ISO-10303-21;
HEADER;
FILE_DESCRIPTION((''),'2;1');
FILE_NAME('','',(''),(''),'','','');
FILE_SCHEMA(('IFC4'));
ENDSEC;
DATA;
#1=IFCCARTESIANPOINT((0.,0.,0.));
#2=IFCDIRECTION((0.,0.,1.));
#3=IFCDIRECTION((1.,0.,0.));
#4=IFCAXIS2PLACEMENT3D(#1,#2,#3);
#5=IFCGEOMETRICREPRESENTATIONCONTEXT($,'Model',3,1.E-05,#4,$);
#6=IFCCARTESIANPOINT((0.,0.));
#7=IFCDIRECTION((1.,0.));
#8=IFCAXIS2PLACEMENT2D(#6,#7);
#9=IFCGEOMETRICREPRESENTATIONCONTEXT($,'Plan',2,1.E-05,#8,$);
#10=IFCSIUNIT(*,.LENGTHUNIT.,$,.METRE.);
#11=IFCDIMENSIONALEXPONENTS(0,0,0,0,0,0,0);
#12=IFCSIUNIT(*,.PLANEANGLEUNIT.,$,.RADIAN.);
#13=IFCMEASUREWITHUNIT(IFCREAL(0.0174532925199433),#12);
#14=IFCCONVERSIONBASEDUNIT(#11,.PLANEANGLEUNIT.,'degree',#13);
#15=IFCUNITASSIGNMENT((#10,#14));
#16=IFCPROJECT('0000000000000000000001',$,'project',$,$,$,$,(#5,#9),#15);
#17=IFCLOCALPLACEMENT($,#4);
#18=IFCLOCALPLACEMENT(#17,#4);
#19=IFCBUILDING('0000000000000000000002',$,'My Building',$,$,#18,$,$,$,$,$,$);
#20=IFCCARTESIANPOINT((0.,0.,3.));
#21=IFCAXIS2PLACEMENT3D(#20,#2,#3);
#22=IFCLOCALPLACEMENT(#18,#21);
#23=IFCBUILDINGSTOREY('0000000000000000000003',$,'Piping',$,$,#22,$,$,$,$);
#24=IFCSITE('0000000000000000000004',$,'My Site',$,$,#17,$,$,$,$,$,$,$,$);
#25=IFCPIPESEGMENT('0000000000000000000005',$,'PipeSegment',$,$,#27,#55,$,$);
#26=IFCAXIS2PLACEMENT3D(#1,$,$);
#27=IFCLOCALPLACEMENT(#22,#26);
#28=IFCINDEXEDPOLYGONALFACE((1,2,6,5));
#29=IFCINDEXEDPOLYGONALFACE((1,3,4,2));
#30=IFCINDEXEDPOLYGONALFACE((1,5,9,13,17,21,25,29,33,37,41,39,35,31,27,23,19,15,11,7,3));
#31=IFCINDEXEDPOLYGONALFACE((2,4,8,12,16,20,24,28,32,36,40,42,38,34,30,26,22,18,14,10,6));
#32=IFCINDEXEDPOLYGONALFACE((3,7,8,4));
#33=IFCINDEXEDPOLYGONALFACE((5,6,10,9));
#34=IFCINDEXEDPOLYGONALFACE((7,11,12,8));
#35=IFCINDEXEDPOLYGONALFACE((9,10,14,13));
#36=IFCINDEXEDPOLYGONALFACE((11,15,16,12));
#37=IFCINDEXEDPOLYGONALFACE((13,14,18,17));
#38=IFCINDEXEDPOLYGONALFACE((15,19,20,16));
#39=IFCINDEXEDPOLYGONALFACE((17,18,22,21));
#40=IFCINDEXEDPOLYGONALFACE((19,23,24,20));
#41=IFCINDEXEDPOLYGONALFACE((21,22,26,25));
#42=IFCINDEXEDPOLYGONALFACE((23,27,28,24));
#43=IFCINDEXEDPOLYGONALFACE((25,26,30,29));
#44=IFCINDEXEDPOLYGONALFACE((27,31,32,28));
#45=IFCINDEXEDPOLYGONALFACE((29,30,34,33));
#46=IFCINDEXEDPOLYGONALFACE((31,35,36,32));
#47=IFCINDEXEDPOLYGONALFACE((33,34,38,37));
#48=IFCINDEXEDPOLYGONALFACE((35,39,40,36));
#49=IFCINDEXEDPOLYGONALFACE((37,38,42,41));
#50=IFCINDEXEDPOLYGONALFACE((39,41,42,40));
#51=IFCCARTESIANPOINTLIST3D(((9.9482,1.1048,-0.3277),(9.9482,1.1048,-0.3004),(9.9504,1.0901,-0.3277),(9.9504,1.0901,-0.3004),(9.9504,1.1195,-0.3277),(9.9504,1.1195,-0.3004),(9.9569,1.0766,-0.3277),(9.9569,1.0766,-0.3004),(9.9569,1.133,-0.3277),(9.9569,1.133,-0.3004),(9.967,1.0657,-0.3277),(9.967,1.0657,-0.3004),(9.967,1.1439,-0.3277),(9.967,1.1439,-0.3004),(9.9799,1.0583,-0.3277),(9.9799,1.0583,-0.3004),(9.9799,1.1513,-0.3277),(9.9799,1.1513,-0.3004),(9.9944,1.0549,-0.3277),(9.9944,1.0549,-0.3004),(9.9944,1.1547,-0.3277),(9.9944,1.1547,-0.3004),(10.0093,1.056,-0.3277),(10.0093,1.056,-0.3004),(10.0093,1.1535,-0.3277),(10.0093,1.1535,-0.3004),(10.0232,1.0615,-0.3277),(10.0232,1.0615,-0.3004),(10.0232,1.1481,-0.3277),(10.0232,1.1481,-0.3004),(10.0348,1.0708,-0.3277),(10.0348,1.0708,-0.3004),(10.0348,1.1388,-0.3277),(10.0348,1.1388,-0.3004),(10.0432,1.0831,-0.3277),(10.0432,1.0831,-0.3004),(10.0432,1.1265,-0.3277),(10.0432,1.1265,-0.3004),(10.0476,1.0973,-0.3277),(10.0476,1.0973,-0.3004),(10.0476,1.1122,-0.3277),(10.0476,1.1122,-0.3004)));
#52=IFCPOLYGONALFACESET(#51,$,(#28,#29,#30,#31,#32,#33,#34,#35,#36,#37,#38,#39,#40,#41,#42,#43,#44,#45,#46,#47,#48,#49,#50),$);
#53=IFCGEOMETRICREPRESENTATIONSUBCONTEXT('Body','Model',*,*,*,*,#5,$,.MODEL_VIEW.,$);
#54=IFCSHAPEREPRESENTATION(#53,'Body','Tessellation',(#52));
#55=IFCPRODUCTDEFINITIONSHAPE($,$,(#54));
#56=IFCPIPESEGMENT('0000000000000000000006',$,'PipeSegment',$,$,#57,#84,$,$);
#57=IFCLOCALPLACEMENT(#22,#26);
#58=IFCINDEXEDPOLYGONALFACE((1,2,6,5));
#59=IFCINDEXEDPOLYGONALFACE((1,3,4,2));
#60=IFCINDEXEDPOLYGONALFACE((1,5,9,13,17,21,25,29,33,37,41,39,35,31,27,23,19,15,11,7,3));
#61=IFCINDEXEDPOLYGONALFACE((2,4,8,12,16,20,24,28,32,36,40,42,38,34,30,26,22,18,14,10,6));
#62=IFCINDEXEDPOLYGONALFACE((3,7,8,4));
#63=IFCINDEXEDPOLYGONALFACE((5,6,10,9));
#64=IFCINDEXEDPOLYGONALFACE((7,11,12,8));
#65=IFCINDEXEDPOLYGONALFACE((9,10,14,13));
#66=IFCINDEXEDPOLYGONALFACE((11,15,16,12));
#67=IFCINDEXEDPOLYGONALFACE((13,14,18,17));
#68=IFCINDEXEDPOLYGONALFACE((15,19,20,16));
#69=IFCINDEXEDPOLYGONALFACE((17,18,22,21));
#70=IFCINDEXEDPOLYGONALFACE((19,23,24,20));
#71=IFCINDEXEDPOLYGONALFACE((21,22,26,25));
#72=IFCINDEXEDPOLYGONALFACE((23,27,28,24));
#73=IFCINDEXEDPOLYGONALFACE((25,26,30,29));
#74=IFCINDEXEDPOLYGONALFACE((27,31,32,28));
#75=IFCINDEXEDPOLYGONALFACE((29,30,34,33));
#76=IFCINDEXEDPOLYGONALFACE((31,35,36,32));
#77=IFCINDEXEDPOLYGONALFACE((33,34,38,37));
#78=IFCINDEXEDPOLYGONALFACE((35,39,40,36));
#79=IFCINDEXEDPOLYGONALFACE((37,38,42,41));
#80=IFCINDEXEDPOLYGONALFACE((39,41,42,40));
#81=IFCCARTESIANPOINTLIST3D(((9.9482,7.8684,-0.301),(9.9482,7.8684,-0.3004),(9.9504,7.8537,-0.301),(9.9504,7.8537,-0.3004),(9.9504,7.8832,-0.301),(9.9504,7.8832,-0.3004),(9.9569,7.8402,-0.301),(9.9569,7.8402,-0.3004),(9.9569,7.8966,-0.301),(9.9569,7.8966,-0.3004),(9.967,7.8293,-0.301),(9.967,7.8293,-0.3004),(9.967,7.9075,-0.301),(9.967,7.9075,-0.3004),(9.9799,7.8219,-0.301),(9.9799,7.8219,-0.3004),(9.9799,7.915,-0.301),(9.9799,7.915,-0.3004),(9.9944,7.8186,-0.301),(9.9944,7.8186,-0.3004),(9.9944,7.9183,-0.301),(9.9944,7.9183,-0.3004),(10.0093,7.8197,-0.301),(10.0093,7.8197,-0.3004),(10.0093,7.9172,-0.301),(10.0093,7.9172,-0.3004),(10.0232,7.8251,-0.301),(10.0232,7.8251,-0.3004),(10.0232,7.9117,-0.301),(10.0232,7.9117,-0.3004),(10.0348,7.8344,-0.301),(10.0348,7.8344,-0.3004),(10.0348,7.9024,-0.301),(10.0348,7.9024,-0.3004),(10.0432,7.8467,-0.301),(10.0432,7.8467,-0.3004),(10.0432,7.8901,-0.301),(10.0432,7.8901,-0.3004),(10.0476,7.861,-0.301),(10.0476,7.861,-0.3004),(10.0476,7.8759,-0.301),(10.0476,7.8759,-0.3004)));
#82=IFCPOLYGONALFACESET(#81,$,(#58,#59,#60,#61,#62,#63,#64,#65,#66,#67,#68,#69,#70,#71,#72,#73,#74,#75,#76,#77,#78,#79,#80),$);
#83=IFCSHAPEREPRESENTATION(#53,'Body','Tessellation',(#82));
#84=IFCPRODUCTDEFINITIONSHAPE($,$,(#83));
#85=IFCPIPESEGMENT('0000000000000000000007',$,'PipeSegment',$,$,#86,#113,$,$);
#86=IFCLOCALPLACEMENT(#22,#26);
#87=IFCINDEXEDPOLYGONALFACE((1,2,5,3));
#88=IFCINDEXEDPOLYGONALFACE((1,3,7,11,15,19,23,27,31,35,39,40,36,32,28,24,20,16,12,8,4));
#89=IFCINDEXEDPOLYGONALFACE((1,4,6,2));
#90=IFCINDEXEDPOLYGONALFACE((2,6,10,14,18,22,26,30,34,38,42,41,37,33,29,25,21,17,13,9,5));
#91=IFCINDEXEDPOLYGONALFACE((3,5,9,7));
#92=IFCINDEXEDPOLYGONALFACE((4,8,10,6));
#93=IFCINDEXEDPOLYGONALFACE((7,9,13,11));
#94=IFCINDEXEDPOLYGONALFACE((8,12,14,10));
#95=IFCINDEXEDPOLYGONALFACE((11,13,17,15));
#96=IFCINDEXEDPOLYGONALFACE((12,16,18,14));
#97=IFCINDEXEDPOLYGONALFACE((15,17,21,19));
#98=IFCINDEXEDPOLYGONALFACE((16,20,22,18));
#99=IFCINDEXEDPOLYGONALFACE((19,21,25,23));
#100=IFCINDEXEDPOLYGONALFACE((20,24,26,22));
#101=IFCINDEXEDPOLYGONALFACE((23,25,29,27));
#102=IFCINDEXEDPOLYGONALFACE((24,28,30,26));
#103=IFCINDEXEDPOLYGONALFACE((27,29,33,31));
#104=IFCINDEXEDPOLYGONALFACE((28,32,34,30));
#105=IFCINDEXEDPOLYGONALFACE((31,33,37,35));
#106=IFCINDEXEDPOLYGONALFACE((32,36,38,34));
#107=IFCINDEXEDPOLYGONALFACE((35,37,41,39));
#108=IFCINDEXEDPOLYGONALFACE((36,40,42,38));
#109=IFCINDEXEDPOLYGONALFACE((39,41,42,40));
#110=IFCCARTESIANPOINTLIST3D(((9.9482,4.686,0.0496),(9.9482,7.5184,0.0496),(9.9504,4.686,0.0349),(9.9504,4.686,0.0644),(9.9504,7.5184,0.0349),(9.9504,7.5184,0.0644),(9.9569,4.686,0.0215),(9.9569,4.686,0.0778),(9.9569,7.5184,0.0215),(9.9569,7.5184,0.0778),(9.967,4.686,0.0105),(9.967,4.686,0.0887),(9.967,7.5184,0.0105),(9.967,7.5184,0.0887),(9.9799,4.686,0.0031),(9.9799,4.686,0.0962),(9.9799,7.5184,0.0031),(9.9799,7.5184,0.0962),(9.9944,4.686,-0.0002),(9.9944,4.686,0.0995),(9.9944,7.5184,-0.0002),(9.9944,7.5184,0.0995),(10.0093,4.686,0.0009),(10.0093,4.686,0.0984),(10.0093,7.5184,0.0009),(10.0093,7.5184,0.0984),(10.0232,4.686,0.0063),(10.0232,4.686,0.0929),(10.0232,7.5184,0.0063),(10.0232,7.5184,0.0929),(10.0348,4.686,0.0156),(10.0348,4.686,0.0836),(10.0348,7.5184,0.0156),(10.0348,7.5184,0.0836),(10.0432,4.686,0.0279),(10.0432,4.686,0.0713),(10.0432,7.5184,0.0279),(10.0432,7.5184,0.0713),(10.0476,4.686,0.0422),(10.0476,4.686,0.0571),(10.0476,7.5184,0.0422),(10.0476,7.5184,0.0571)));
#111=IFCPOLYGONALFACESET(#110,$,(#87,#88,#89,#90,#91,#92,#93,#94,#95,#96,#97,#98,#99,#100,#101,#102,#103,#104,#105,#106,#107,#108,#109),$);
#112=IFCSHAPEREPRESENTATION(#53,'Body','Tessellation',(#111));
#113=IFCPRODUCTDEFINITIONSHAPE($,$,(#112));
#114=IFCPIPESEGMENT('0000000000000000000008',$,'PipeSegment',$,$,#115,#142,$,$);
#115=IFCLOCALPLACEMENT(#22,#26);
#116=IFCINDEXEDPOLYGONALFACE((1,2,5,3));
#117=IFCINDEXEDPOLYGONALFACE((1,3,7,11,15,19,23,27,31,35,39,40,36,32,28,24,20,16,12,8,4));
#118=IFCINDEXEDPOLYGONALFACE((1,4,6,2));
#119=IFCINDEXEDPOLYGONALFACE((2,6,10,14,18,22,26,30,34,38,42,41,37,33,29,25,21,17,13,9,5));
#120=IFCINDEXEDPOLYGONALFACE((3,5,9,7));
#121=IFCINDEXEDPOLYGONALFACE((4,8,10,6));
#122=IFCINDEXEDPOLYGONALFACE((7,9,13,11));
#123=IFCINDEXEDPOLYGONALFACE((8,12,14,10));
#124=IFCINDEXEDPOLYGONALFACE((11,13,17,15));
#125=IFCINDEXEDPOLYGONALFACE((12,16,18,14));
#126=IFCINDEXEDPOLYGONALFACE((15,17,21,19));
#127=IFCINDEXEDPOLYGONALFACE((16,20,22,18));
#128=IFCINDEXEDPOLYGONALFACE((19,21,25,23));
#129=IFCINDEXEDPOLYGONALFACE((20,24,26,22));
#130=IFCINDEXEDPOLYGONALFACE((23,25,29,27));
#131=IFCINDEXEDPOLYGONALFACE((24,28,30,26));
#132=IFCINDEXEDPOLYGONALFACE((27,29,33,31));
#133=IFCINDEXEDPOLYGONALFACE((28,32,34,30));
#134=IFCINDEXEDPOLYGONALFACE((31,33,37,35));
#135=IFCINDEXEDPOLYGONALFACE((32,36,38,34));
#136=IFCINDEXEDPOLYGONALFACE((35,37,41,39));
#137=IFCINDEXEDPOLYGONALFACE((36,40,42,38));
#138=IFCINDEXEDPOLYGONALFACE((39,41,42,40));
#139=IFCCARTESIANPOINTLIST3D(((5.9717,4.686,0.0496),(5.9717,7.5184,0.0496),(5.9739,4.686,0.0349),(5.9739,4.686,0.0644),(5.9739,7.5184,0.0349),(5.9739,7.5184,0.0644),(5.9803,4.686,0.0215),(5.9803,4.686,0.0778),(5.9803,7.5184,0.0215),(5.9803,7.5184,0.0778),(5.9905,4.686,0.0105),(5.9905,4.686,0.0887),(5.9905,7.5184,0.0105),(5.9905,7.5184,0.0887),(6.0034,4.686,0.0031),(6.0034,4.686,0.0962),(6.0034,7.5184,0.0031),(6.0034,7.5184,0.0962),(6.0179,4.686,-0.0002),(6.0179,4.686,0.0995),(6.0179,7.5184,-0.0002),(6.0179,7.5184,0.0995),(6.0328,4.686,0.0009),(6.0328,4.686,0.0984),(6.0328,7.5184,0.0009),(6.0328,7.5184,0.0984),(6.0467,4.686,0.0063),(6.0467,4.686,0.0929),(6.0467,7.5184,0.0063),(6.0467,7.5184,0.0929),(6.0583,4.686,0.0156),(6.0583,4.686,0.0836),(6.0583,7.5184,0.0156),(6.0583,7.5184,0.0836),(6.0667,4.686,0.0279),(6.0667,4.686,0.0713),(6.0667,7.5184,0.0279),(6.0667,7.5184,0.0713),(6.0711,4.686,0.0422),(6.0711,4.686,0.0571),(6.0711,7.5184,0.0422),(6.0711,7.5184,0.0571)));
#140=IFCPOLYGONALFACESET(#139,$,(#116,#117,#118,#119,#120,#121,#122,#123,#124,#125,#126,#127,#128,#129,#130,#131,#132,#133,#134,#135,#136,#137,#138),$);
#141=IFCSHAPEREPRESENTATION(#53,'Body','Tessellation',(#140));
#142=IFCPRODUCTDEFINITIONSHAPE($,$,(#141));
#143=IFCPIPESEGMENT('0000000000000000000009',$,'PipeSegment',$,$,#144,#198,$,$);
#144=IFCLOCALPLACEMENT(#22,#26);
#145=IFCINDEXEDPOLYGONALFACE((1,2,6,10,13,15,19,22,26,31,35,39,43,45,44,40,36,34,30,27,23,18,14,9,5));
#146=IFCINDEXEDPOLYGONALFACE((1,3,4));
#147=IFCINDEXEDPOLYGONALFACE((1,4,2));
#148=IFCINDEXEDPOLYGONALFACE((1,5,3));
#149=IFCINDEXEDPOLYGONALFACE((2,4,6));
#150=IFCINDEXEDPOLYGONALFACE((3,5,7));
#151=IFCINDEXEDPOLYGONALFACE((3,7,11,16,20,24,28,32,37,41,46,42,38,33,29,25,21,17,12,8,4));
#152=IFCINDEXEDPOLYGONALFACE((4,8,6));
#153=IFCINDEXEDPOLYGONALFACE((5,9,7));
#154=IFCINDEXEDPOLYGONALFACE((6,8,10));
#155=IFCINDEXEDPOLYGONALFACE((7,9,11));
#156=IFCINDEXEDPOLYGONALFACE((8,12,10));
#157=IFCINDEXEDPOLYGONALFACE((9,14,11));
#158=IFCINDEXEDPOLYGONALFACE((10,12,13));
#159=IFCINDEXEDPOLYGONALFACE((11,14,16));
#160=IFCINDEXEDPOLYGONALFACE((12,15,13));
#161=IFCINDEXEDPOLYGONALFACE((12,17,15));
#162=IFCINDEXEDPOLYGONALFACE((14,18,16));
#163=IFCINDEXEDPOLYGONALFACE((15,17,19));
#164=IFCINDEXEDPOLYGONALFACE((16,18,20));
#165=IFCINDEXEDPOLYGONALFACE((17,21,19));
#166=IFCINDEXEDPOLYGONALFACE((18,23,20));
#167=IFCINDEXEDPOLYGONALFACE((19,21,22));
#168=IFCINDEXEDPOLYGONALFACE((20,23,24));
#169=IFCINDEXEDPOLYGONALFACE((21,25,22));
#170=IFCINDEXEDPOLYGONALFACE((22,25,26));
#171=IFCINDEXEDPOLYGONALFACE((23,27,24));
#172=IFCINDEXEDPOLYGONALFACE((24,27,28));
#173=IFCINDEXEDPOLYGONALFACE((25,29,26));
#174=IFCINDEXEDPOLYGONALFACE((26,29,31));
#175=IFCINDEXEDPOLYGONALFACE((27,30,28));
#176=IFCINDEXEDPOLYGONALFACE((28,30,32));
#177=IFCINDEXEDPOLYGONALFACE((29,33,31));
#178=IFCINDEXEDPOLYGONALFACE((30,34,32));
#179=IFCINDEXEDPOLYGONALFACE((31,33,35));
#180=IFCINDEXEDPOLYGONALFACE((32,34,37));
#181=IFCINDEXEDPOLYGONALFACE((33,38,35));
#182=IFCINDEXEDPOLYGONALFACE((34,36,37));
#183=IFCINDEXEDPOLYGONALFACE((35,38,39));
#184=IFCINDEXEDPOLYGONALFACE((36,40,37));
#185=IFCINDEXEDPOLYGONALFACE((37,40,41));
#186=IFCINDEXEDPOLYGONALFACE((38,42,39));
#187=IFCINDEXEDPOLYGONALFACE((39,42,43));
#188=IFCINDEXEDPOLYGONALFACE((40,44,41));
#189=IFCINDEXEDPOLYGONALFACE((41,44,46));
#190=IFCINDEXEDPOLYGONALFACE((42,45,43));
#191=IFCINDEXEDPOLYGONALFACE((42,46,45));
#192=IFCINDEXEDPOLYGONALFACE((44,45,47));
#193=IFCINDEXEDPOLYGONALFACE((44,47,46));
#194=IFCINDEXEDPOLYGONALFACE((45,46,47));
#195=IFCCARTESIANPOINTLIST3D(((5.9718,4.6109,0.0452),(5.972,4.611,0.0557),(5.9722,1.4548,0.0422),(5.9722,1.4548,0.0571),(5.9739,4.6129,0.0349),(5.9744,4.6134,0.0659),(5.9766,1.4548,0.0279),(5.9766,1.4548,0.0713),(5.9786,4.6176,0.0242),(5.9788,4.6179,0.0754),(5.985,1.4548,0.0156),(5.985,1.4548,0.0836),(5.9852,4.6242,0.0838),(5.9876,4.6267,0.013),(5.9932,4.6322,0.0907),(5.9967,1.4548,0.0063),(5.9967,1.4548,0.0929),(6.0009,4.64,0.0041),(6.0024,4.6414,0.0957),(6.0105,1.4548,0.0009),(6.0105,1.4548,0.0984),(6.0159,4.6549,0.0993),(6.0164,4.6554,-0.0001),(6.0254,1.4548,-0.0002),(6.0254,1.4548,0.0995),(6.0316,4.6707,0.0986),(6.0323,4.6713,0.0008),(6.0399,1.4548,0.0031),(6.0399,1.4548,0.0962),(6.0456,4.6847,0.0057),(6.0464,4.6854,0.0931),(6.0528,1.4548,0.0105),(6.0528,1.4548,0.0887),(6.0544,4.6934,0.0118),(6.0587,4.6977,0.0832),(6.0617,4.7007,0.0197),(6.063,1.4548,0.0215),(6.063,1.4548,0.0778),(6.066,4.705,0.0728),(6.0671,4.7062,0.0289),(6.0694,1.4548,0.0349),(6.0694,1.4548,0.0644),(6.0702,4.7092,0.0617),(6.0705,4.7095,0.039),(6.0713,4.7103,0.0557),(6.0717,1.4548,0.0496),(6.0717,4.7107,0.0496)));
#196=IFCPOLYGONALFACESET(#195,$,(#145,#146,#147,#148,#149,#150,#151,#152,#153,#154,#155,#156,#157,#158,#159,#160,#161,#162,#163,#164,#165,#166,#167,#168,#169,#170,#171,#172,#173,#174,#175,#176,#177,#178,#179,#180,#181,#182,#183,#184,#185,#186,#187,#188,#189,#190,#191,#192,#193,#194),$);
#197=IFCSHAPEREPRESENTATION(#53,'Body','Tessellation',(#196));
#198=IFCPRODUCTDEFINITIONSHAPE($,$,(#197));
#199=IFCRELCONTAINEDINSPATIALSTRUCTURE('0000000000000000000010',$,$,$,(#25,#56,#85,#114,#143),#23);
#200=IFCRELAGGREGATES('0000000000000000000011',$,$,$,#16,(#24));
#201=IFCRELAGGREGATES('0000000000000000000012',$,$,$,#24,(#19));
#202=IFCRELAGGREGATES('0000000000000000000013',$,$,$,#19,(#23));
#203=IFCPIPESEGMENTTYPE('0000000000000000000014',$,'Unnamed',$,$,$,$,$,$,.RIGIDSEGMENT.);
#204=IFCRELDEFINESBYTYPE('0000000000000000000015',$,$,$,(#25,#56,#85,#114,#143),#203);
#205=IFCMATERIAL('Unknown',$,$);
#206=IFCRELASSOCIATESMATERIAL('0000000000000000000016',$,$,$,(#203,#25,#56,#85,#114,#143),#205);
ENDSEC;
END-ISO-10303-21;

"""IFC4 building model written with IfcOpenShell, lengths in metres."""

from ifc_helpers import new_model, entity, si_unit, converted_unit, frame, origin_with_axes, origin_2d_with_axis, place, context, subcontext, project, spatial, circle, extrude, clip, halfspace, material, material_profile, profile_set, profile_usage, type_object, element, save


model = new_model("IFC4")

# Units and contexts
model_context = context("Model", 3, precision=1e-05, world=origin_with_axes())
plan_context = context("Plan", 2, precision=1e-05, world=origin_2d_with_axis())
body_context = subcontext(model_context, "Body", "Model", "MODEL_VIEW")
ifc_project = project(units=[si_unit("LENGTHUNIT", "METRE"), converted_unit("PLANEANGLEUNIT", "degree", entity("IfcReal", 0.0174532925199433), si_unit("PLANEANGLEUNIT", "RADIAN"), dimensions=[0, 0, 0, 0, 0, 0, 0])], contexts=[model_context, plan_context])

# Site, building, storey
site_placement = place(None, origin_with_axes())
site = spatial("IfcSite", under=ifc_project, at=site_placement, Name="My Site")
building_placement = place(site_placement, origin_with_axes())
building = spatial("IfcBuilding", under=site, at=building_placement, Name="My Building")
storey_placement = place(building_placement, frame((0.0, 0.0, 3.0), z_axis=(0.0, 0.0, 1.0), x_axis=(1.0, 0.0, 0.0)))
storey = spatial("IfcBuildingStorey", under=building, at=storey_placement, Name="Piping")

# Pipe segments
ifc_material = material(Name="Unknown")
ifc_material_profile = material_profile(ifc_material, circle(Radius=0.05))
ifc_profile_set = profile_set([ifc_material_profile])
pipe_segment_type = type_object("IfcPipeSegmentType", Name="Unnamed", PredefinedType="RIGIDSEGMENT", material=ifc_profile_set)
ifc_profile_usage_1 = profile_usage(ifc_profile_set, cardinal=5)
pipe_segment_1_placement = place(storey_placement, frame((9.9982, 1.1048, -0.3004), z_axis=(0.0, 0.0, -1.0), x_axis=(-1.0, 0.0, 0.0)))
element("IfcPipeSegment", 1, at=pipe_segment_1_placement, inside=storey, type_object=pipe_segment_type, material=ifc_profile_usage_1, Name="PipeSegment", context=body_context, shape_type="SweptSolid", body=[
    extrude(circle(Radius=0.05), origin_with_axes(), (0.0, 0.0, 1.0), 0.0273),
])
ifc_profile_usage_2 = profile_usage(ifc_profile_set, cardinal=5)
pipe_segment_2_placement = place(storey_placement, frame((9.9982, 7.8684, -0.3004), z_axis=(0.0, 0.0, -1.0), x_axis=(-1.0, 0.0, 0.0)))
element("IfcPipeSegment", 2, at=pipe_segment_2_placement, inside=storey, type_object=pipe_segment_type, material=ifc_profile_usage_2, Name="PipeSegment", context=body_context, shape_type="SweptSolid", body=[
    extrude(circle(Radius=0.05), origin_with_axes(), (0.0, 0.0, 1.0), 0.0007),
])
ifc_profile_usage_3 = profile_usage(ifc_profile_set, cardinal=5)
pipe_segment_3_placement = place(storey_placement, frame((9.9982, 4.686, 0.0496), z_axis=(0.0, 1.0, 0.0), x_axis=(-1.0, 0.0, 0.0)))
element("IfcPipeSegment", 3, at=pipe_segment_3_placement, inside=storey, type_object=pipe_segment_type, material=ifc_profile_usage_3, Name="PipeSegment", context=body_context, shape_type="SweptSolid", body=[
    extrude(circle(Radius=0.05), origin_with_axes(), (0.0, 0.0, 1.0), 2.8324),
])
ifc_profile_usage_4 = profile_usage(ifc_profile_set, cardinal=5)
pipe_segment_4_placement = place(storey_placement, frame((6.0217, 4.686, 0.0496), z_axis=(0.0, 1.0, 0.0), x_axis=(-1.0, 0.0, 0.0)))
element("IfcPipeSegment", 4, at=pipe_segment_4_placement, inside=storey, type_object=pipe_segment_type, material=ifc_profile_usage_4, Name="PipeSegment", context=body_context, shape_type="SweptSolid", body=[
    extrude(circle(Radius=0.05), origin_with_axes(), (0.0, 0.0, 1.0), 2.8324),
])
ifc_profile_usage_5 = profile_usage(ifc_profile_set, cardinal=5)
pipe_segment_5_placement = place(storey_placement, frame((6.0217, 4.7107, 0.0496), z_axis=(0.0, -1.0, 0.000007), x_axis=(1.0, 0.0, 0.0)))
element("IfcPipeSegment", 5, at=pipe_segment_5_placement, inside=storey, type_object=pipe_segment_type, material=ifc_profile_usage_5, Name="PipeSegment", context=body_context, shape_type="Clipping", body=[
    clip(extrude(circle(Radius=0.05), origin_with_axes(), (0.0, 0.0, 1.0), 3.2559), halfspace(frame((0.05, -3.0496, 0.0), z_axis=(-0.707114, 0.000005, -0.7071), x_axis=(0.000007, 1.0, 0.0)), False)),
])

save(model, "model.ifc")
